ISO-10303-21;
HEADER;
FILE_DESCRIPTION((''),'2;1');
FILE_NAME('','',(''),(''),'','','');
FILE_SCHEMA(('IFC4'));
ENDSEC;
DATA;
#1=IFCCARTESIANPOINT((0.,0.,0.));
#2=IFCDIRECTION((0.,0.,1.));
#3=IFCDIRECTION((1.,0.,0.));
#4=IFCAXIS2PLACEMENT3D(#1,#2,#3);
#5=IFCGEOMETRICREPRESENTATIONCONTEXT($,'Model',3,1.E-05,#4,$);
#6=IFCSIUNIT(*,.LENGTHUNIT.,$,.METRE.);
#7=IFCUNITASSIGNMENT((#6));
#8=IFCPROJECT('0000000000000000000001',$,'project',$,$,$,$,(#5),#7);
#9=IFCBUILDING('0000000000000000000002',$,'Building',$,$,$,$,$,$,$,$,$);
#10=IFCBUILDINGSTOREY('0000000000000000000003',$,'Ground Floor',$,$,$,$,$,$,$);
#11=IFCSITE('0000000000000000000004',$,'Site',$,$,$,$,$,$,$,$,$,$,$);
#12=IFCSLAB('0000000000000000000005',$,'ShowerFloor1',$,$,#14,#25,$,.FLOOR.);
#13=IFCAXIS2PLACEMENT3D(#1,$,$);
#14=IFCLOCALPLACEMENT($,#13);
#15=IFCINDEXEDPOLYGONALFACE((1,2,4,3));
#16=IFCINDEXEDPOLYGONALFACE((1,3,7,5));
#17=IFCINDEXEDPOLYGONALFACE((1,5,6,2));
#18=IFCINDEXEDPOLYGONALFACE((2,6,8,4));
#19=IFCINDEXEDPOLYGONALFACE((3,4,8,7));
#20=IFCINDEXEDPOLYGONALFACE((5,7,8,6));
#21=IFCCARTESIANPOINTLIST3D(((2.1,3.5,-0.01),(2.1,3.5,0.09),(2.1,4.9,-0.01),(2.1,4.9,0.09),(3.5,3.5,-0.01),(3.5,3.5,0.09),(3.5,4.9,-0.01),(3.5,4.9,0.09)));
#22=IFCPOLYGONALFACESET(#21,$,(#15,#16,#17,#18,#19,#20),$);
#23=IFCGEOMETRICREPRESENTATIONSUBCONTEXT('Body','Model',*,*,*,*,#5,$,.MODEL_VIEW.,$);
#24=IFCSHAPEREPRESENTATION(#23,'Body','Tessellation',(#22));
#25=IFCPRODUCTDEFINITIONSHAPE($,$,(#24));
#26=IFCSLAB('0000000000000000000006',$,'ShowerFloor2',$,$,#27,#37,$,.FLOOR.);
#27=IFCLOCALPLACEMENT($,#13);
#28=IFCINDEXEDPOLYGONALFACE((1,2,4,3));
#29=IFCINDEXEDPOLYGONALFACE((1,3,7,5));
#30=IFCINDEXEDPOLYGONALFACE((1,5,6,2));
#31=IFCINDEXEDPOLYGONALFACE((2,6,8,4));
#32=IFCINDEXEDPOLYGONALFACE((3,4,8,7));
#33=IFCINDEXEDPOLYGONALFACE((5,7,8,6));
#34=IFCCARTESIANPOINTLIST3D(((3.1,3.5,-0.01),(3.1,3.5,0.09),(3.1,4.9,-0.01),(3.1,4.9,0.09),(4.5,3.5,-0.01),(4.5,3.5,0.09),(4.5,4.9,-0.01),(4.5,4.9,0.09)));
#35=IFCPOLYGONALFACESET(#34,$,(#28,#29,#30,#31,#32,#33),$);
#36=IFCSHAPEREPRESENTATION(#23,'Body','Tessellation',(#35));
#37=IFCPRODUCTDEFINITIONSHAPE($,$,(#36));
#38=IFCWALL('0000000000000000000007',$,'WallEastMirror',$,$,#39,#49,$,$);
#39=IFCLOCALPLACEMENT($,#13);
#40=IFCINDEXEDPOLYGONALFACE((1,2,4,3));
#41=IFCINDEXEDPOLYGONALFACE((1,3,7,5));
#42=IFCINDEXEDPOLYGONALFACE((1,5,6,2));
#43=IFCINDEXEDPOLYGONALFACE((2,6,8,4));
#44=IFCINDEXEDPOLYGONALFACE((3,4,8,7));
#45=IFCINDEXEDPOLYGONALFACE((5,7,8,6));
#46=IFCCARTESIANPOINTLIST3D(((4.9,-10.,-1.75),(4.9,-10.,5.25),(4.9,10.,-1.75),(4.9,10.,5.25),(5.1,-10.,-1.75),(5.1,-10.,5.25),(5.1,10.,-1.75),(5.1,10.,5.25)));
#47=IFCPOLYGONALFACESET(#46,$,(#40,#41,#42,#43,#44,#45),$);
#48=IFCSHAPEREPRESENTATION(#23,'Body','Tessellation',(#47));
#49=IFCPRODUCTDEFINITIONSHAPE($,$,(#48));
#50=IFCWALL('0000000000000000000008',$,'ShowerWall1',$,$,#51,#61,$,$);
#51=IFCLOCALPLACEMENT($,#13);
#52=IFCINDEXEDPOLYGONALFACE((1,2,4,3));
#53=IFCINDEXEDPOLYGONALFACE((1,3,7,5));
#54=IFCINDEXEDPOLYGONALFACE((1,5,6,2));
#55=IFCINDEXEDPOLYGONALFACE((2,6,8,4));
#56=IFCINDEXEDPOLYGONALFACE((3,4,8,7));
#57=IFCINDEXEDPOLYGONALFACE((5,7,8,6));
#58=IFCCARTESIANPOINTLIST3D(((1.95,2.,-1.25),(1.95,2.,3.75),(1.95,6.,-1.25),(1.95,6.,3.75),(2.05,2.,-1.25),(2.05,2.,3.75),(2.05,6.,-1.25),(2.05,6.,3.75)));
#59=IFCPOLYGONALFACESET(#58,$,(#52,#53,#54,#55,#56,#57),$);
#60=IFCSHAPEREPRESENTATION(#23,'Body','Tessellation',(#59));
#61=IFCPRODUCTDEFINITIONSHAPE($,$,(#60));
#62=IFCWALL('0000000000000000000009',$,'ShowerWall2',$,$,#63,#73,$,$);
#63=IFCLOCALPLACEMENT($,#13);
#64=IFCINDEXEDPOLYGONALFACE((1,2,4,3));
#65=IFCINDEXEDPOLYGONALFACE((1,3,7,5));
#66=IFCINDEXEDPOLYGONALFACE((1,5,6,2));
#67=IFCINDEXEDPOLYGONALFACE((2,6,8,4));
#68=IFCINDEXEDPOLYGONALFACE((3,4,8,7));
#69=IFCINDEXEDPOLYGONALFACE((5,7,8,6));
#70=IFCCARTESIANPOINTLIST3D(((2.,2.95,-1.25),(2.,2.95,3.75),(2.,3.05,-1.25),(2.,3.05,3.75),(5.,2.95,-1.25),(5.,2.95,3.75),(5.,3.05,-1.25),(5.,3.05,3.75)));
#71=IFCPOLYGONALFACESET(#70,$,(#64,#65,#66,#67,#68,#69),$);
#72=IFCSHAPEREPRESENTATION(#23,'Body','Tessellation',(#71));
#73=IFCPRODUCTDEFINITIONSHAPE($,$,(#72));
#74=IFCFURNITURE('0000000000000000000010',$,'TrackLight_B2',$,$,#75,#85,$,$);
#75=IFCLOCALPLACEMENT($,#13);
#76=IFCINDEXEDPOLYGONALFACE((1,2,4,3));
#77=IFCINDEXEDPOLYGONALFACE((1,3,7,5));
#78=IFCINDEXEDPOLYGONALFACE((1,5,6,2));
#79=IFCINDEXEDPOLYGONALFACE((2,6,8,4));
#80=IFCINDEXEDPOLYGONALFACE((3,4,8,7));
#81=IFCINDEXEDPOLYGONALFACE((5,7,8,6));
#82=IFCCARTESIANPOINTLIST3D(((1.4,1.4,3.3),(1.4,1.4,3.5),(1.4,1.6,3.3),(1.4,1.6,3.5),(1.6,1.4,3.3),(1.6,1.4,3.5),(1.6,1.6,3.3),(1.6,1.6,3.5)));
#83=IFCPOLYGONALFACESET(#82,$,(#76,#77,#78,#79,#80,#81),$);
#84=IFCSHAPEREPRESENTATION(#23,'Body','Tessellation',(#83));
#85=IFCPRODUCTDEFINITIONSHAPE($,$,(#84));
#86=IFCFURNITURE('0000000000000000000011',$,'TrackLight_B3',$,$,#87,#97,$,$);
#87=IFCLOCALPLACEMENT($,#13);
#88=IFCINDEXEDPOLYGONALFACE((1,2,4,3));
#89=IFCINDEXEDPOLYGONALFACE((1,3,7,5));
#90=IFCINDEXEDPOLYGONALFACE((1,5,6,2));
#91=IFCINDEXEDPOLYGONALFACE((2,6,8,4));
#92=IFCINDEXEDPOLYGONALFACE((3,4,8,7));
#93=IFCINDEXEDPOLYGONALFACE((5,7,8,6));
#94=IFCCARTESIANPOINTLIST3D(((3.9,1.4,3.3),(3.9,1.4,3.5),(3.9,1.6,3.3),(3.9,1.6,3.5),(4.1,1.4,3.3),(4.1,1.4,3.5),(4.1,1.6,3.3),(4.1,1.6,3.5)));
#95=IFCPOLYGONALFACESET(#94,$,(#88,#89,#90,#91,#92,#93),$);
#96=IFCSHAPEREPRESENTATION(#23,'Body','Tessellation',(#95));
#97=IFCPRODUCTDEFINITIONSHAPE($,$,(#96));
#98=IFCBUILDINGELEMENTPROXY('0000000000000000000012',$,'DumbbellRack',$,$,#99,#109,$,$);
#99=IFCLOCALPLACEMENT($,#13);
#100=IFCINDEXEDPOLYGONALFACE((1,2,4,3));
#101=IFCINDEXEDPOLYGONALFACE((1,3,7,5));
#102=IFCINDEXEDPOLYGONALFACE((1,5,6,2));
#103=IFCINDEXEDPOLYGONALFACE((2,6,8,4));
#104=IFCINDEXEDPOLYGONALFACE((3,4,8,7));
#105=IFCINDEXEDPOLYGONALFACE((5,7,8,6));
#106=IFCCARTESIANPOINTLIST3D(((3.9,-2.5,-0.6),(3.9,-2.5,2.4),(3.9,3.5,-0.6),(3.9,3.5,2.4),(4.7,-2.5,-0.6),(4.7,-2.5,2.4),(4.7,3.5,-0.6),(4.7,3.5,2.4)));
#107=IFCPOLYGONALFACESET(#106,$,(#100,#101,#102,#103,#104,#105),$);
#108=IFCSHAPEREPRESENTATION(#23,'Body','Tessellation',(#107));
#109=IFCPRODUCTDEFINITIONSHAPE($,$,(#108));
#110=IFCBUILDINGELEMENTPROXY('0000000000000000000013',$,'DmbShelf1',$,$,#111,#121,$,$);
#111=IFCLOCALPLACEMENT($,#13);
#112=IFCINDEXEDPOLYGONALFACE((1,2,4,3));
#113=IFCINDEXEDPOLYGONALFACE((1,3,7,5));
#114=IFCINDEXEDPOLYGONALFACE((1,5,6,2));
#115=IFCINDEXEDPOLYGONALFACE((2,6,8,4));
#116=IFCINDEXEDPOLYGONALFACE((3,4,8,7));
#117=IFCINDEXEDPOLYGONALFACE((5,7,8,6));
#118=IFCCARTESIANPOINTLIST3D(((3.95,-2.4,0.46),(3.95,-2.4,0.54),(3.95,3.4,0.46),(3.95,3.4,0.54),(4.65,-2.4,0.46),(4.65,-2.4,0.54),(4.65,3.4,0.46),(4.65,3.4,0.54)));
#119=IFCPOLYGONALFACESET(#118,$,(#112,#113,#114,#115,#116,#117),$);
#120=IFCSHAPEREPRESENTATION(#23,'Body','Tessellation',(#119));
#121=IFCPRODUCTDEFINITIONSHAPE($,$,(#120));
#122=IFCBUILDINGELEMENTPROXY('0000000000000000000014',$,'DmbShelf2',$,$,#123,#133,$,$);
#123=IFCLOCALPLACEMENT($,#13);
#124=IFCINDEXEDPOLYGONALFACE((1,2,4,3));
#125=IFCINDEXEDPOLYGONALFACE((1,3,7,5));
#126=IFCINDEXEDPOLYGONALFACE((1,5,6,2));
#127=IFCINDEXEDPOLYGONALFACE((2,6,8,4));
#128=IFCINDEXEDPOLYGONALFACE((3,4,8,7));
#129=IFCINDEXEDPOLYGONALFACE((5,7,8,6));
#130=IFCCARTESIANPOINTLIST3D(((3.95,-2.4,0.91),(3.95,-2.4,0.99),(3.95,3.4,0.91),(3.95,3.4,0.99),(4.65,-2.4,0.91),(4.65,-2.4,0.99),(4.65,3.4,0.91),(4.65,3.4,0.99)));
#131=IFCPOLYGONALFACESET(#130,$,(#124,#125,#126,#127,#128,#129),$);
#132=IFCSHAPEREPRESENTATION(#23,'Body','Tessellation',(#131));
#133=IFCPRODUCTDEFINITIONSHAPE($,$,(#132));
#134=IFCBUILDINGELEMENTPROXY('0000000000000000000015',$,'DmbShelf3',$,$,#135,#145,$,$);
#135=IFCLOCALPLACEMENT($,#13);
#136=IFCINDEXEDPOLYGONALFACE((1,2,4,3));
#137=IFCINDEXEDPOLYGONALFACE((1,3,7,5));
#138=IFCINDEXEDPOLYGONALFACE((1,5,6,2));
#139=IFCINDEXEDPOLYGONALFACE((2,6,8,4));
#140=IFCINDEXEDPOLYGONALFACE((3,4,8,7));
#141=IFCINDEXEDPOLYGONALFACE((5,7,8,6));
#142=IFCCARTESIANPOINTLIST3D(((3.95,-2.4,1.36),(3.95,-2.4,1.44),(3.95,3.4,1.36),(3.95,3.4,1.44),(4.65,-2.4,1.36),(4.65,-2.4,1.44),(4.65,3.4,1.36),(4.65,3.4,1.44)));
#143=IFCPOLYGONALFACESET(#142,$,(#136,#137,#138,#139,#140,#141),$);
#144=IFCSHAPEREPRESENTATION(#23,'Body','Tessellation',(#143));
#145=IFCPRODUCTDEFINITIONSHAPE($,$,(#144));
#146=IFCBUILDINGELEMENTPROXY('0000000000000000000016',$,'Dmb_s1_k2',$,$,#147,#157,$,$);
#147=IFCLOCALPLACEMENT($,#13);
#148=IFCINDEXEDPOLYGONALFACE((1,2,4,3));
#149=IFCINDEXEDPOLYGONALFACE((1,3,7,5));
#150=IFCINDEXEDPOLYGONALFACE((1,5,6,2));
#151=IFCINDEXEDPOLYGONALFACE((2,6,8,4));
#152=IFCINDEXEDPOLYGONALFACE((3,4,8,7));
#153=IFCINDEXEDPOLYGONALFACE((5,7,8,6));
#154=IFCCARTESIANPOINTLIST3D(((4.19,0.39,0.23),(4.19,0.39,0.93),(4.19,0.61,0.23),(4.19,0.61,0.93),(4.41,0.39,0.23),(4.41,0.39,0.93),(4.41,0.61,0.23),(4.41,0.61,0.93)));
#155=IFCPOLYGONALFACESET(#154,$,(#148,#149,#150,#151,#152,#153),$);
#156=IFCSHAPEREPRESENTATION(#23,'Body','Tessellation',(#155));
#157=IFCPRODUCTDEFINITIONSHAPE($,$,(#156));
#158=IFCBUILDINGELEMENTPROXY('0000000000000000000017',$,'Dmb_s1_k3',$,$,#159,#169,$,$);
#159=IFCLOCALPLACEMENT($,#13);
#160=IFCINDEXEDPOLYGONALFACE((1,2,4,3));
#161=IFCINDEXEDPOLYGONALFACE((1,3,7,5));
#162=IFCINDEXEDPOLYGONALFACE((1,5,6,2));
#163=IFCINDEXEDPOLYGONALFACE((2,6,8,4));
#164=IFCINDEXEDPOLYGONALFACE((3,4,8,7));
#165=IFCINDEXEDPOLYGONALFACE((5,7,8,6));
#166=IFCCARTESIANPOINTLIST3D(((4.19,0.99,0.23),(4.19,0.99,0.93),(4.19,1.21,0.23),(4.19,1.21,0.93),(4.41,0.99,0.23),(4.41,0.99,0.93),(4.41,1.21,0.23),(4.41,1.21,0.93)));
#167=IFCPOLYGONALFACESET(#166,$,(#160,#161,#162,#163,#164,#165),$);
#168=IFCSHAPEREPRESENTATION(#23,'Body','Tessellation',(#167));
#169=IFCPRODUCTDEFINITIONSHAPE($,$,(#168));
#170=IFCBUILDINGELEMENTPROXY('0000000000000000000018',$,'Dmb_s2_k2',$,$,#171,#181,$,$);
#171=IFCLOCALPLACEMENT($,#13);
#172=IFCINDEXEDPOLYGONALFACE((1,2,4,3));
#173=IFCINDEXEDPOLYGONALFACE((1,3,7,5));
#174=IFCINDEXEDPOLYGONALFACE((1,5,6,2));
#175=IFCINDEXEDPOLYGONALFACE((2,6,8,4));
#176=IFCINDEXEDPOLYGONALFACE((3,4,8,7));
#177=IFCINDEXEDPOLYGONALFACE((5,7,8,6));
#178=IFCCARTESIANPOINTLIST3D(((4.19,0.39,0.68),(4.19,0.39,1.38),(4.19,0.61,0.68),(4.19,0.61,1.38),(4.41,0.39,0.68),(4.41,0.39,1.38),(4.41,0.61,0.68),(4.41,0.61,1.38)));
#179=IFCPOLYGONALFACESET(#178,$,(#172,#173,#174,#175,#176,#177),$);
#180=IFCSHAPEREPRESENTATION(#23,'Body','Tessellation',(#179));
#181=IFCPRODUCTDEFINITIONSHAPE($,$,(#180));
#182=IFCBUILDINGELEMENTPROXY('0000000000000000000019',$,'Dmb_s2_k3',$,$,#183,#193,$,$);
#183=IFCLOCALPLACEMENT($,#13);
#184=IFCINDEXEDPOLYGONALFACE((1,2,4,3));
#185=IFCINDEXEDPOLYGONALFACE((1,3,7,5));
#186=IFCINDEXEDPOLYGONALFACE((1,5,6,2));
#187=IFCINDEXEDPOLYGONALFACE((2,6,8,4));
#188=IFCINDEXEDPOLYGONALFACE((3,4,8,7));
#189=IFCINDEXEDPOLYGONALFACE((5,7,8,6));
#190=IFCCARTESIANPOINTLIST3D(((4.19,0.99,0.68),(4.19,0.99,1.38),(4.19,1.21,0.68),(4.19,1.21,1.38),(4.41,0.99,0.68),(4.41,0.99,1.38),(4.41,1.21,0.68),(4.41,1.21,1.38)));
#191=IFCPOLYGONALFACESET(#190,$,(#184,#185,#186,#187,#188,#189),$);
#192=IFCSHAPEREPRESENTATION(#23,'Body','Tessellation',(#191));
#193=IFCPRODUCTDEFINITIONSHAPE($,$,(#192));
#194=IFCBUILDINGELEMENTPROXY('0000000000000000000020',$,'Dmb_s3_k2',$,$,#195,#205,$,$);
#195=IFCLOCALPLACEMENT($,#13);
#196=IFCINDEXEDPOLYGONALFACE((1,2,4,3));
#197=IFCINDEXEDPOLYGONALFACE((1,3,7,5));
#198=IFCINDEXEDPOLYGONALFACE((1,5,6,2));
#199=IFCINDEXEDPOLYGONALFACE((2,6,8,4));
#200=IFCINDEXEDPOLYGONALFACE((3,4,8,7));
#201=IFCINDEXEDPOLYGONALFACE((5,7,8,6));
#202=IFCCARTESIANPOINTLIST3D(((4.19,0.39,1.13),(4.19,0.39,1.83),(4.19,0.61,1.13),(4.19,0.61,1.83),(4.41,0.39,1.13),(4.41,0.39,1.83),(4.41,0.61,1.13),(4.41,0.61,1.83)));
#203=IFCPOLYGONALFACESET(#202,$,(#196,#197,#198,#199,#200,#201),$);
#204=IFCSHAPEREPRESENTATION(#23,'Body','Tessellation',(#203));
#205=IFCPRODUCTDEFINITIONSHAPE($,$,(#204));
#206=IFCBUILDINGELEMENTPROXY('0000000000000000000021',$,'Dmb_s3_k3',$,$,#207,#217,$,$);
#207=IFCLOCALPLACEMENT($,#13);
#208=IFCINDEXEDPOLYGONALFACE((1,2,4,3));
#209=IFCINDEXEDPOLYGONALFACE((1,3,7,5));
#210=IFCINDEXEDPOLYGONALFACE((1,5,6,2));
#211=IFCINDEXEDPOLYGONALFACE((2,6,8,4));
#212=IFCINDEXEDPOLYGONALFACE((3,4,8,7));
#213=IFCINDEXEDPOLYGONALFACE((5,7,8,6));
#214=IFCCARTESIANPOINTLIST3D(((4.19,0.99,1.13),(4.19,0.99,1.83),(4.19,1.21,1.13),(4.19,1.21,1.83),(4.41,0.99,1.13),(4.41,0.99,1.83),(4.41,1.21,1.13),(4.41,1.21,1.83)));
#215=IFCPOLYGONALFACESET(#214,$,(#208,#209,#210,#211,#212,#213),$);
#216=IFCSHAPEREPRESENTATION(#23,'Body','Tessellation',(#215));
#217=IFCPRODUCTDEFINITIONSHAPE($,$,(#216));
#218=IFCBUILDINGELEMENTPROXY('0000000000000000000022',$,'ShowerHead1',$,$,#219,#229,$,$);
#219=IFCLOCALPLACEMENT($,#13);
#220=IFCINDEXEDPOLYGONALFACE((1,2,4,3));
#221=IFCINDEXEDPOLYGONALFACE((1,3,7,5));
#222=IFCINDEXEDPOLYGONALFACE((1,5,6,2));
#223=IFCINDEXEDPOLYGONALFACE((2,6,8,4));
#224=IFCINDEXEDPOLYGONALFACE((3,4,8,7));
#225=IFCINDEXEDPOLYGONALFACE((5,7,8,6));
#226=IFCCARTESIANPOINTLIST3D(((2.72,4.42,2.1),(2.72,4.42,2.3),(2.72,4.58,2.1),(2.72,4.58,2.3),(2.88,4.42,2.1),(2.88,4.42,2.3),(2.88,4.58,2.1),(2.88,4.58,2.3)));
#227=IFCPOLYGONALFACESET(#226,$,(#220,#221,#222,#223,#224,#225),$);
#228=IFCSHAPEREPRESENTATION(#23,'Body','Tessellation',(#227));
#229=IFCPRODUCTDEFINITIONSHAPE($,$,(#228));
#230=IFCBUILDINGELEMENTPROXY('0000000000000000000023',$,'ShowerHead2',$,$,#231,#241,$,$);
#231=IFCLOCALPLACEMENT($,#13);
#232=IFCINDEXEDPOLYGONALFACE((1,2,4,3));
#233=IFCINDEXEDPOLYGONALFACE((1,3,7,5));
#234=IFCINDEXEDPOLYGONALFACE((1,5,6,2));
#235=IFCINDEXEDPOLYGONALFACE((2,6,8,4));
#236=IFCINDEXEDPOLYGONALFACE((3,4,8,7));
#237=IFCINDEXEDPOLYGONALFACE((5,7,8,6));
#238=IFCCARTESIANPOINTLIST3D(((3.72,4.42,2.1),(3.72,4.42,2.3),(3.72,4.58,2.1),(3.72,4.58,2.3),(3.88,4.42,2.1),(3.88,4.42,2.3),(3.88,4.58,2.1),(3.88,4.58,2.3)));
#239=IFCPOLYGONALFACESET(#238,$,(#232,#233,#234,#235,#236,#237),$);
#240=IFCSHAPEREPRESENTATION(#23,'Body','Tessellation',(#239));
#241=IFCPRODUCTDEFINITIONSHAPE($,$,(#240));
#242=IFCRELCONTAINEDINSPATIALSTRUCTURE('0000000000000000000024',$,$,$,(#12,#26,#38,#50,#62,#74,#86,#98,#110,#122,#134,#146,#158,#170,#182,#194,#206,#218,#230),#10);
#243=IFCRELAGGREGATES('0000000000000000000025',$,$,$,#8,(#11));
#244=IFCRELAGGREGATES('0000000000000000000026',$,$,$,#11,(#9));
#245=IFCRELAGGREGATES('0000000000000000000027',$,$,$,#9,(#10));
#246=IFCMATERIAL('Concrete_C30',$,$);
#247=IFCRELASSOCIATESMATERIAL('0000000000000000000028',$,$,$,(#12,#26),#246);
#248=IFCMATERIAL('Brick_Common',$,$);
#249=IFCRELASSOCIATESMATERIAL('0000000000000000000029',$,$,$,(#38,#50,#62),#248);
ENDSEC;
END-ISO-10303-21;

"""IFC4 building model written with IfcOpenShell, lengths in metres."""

from ifc_helpers import new_model, si_unit, frame, origin_with_axes, origin_2d, place, context, subcontext, project, spatial, rectangle, extrude, material, element, save


model = new_model("IFC4")

# Units and contexts
model_context = context("Model", 3, precision=1e-05, world=origin_with_axes())
body_context = subcontext(model_context, "Body", "Model", "MODEL_VIEW")
ifc_project = project(units=[si_unit("LENGTHUNIT", "METRE")], contexts=[model_context])

# Site, building, storey
site = spatial("IfcSite", under=ifc_project, Name="Site")
building = spatial("IfcBuilding", under=site, Name="Building")
storey = spatial("IfcBuildingStorey", under=building, Name="Ground Floor")

# Slabs
ifc_material_1 = material(Name="Concrete_C30")
for number, where, z_axis, x_axis, name in (
    (1, (2.8, 4.2, 0.04), (0.0, 0.0, 1.0), (1.0, 0.0, 0.0), "ShowerFloor1"),
    (2, (3.8, 4.2, 0.04), (0.0, 0.0, 1.0), (1.0, 0.0, 0.0), "ShowerFloor2"),
):
    element("IfcSlab", number, at=place(None, frame(where, z_axis=z_axis, x_axis=x_axis)), inside=storey, material=ifc_material_1, Name=name, PredefinedType="FLOOR", context=body_context, shape_type="SweptSolid", body=[
        extrude(rectangle(XDim=1.4, YDim=1.4, at=origin_2d()), frame((0.0, 0.0, -0.05)), (0.0, 0.0, 1.0), 0.1),
    ])

# Walls
ifc_material_2 = material(Name="Brick_Common")
wall_1_placement = place(None, frame((5.0, 0.0, 1.75), z_axis=(0.0, 0.0, 1.0), x_axis=(1.0, 0.0, 0.0)))
element("IfcWall", 3, at=wall_1_placement, inside=storey, material=ifc_material_2, Name="WallEastMirror", context=body_context, shape_type="SweptSolid", body=[
    extrude(rectangle(XDim=0.2, YDim=20.0, at=origin_2d()), frame((0.0, 0.0, -3.5)), (0.0, 0.0, 1.0), 7.0),
])
wall_2_placement = place(None, frame((2.0, 4.0, 1.25), z_axis=(0.0, 0.0, 1.0), x_axis=(1.0, 0.0, 0.0)))
element("IfcWall", 4, at=wall_2_placement, inside=storey, material=ifc_material_2, Name="ShowerWall1", context=body_context, shape_type="SweptSolid", body=[
    extrude(rectangle(XDim=0.1, YDim=4.0, at=origin_2d()), frame((0.0, 0.0, -2.5)), (0.0, 0.0, 1.0), 5.0),
])
wall_3_placement = place(None, frame((3.5, 3.0, 1.25), z_axis=(0.0, 0.0, 1.0), x_axis=(1.0, 0.0, 0.0)))
element("IfcWall", 5, at=wall_3_placement, inside=storey, material=ifc_material_2, Name="ShowerWall2", context=body_context, shape_type="SweptSolid", body=[
    extrude(rectangle(XDim=3.0, YDim=0.1, at=origin_2d()), frame((0.0, 0.0, -2.5)), (0.0, 0.0, 1.0), 5.0),
])

# Furniture
for number, where, z_axis, x_axis, name in (
    (6, (1.5, 1.5, 3.4), (0.0, 0.0, 1.0), (1.0, 0.0, 0.0), "TrackLight_B2"),
    (7, (4.0, 1.5, 3.4), (0.0, 0.0, 1.0), (1.0, 0.0, 0.0), "TrackLight_B3"),
):
    element("IfcFurniture", number, at=place(None, frame(where, z_axis=z_axis, x_axis=x_axis)), inside=storey, Name=name, context=body_context, shape_type="SweptSolid", body=[
        extrude(rectangle(XDim=0.2, YDim=0.2, at=origin_2d()), frame((0.0, 0.0, -0.1)), (0.0, 0.0, 1.0), 0.2),
    ])

# Building element proxies
proxy_1_placement = place(None, frame((4.3, 0.5, 0.9), z_axis=(0.0, 0.0, 1.0), x_axis=(1.0, 0.0, 0.0)))
element("IfcBuildingElementProxy", 8, at=proxy_1_placement, inside=storey, Name="DumbbellRack", context=body_context, shape_type="SweptSolid", body=[
    extrude(rectangle(XDim=0.8, YDim=6.0, at=origin_2d()), frame((0.0, 0.0, -1.5)), (0.0, 0.0, 1.0), 3.0),
])
for number, where, z_axis, x_axis, name in (
    (9, (4.3, 0.5, 0.5), (0.0, 0.0, 1.0), (1.0, 0.0, 0.0), "DmbShelf1"),
    (10, (4.3, 0.5, 0.95), (0.0, 0.0, 1.0), (1.0, 0.0, 0.0), "DmbShelf2"),
    (11, (4.3, 0.5, 1.4), (0.0, 0.0, 1.0), (1.0, 0.0, 0.0), "DmbShelf3"),
):
    element("IfcBuildingElementProxy", number, at=place(None, frame(where, z_axis=z_axis, x_axis=x_axis)), inside=storey, Name=name, context=body_context, shape_type="SweptSolid", body=[
        extrude(rectangle(XDim=0.7, YDim=5.8, at=origin_2d()), frame((0.0, 0.0, -0.04)), (0.0, 0.0, 1.0), 0.08),
    ])
for number, where, z_axis, x_axis, name in (
    (12, (4.3, 0.5, 0.58), (0.0, 0.0, 1.0), (1.0, 0.0, 0.0), "Dmb_s1_k2"),
    (13, (4.3, 1.1, 0.58), (0.0, 0.0, 1.0), (1.0, 0.0, 0.0), "Dmb_s1_k3"),
    (14, (4.3, 0.5, 1.03), (0.0, 0.0, 1.0), (1.0, 0.0, 0.0), "Dmb_s2_k2"),
    (15, (4.3, 1.1, 1.03), (0.0, 0.0, 1.0), (1.0, 0.0, 0.0), "Dmb_s2_k3"),
    (16, (4.3, 0.5, 1.48), (0.0, 0.0, 1.0), (1.0, 0.0, 0.0), "Dmb_s3_k2"),
    (17, (4.3, 1.1, 1.48), (0.0, 0.0, 1.0), (1.0, 0.0, 0.0), "Dmb_s3_k3"),
):
    element("IfcBuildingElementProxy", number, at=place(None, frame(where, z_axis=z_axis, x_axis=x_axis)), inside=storey, Name=name, context=body_context, shape_type="SweptSolid", body=[
        extrude(rectangle(XDim=0.22, YDim=0.22, at=origin_2d()), frame((0.0, 0.0, -0.35)), (0.0, 0.0, 1.0), 0.7),
    ])
for number, where, z_axis, x_axis, name in (
    (18, (2.8, 4.5, 2.2), (0.0, 0.0, 1.0), (1.0, 0.0, 0.0), "ShowerHead1"),
    (19, (3.8, 4.5, 2.2), (0.0, 0.0, 1.0), (1.0, 0.0, 0.0), "ShowerHead2"),
):
    element("IfcBuildingElementProxy", number, at=place(None, frame(where, z_axis=z_axis, x_axis=x_axis)), inside=storey, Name=name, context=body_context, shape_type="SweptSolid", body=[
        extrude(rectangle(XDim=0.16, YDim=0.16, at=origin_2d()), frame((0.0, 0.0, -0.1)), (0.0, 0.0, 1.0), 0.2),
    ])

save(model, "model.ifc")
